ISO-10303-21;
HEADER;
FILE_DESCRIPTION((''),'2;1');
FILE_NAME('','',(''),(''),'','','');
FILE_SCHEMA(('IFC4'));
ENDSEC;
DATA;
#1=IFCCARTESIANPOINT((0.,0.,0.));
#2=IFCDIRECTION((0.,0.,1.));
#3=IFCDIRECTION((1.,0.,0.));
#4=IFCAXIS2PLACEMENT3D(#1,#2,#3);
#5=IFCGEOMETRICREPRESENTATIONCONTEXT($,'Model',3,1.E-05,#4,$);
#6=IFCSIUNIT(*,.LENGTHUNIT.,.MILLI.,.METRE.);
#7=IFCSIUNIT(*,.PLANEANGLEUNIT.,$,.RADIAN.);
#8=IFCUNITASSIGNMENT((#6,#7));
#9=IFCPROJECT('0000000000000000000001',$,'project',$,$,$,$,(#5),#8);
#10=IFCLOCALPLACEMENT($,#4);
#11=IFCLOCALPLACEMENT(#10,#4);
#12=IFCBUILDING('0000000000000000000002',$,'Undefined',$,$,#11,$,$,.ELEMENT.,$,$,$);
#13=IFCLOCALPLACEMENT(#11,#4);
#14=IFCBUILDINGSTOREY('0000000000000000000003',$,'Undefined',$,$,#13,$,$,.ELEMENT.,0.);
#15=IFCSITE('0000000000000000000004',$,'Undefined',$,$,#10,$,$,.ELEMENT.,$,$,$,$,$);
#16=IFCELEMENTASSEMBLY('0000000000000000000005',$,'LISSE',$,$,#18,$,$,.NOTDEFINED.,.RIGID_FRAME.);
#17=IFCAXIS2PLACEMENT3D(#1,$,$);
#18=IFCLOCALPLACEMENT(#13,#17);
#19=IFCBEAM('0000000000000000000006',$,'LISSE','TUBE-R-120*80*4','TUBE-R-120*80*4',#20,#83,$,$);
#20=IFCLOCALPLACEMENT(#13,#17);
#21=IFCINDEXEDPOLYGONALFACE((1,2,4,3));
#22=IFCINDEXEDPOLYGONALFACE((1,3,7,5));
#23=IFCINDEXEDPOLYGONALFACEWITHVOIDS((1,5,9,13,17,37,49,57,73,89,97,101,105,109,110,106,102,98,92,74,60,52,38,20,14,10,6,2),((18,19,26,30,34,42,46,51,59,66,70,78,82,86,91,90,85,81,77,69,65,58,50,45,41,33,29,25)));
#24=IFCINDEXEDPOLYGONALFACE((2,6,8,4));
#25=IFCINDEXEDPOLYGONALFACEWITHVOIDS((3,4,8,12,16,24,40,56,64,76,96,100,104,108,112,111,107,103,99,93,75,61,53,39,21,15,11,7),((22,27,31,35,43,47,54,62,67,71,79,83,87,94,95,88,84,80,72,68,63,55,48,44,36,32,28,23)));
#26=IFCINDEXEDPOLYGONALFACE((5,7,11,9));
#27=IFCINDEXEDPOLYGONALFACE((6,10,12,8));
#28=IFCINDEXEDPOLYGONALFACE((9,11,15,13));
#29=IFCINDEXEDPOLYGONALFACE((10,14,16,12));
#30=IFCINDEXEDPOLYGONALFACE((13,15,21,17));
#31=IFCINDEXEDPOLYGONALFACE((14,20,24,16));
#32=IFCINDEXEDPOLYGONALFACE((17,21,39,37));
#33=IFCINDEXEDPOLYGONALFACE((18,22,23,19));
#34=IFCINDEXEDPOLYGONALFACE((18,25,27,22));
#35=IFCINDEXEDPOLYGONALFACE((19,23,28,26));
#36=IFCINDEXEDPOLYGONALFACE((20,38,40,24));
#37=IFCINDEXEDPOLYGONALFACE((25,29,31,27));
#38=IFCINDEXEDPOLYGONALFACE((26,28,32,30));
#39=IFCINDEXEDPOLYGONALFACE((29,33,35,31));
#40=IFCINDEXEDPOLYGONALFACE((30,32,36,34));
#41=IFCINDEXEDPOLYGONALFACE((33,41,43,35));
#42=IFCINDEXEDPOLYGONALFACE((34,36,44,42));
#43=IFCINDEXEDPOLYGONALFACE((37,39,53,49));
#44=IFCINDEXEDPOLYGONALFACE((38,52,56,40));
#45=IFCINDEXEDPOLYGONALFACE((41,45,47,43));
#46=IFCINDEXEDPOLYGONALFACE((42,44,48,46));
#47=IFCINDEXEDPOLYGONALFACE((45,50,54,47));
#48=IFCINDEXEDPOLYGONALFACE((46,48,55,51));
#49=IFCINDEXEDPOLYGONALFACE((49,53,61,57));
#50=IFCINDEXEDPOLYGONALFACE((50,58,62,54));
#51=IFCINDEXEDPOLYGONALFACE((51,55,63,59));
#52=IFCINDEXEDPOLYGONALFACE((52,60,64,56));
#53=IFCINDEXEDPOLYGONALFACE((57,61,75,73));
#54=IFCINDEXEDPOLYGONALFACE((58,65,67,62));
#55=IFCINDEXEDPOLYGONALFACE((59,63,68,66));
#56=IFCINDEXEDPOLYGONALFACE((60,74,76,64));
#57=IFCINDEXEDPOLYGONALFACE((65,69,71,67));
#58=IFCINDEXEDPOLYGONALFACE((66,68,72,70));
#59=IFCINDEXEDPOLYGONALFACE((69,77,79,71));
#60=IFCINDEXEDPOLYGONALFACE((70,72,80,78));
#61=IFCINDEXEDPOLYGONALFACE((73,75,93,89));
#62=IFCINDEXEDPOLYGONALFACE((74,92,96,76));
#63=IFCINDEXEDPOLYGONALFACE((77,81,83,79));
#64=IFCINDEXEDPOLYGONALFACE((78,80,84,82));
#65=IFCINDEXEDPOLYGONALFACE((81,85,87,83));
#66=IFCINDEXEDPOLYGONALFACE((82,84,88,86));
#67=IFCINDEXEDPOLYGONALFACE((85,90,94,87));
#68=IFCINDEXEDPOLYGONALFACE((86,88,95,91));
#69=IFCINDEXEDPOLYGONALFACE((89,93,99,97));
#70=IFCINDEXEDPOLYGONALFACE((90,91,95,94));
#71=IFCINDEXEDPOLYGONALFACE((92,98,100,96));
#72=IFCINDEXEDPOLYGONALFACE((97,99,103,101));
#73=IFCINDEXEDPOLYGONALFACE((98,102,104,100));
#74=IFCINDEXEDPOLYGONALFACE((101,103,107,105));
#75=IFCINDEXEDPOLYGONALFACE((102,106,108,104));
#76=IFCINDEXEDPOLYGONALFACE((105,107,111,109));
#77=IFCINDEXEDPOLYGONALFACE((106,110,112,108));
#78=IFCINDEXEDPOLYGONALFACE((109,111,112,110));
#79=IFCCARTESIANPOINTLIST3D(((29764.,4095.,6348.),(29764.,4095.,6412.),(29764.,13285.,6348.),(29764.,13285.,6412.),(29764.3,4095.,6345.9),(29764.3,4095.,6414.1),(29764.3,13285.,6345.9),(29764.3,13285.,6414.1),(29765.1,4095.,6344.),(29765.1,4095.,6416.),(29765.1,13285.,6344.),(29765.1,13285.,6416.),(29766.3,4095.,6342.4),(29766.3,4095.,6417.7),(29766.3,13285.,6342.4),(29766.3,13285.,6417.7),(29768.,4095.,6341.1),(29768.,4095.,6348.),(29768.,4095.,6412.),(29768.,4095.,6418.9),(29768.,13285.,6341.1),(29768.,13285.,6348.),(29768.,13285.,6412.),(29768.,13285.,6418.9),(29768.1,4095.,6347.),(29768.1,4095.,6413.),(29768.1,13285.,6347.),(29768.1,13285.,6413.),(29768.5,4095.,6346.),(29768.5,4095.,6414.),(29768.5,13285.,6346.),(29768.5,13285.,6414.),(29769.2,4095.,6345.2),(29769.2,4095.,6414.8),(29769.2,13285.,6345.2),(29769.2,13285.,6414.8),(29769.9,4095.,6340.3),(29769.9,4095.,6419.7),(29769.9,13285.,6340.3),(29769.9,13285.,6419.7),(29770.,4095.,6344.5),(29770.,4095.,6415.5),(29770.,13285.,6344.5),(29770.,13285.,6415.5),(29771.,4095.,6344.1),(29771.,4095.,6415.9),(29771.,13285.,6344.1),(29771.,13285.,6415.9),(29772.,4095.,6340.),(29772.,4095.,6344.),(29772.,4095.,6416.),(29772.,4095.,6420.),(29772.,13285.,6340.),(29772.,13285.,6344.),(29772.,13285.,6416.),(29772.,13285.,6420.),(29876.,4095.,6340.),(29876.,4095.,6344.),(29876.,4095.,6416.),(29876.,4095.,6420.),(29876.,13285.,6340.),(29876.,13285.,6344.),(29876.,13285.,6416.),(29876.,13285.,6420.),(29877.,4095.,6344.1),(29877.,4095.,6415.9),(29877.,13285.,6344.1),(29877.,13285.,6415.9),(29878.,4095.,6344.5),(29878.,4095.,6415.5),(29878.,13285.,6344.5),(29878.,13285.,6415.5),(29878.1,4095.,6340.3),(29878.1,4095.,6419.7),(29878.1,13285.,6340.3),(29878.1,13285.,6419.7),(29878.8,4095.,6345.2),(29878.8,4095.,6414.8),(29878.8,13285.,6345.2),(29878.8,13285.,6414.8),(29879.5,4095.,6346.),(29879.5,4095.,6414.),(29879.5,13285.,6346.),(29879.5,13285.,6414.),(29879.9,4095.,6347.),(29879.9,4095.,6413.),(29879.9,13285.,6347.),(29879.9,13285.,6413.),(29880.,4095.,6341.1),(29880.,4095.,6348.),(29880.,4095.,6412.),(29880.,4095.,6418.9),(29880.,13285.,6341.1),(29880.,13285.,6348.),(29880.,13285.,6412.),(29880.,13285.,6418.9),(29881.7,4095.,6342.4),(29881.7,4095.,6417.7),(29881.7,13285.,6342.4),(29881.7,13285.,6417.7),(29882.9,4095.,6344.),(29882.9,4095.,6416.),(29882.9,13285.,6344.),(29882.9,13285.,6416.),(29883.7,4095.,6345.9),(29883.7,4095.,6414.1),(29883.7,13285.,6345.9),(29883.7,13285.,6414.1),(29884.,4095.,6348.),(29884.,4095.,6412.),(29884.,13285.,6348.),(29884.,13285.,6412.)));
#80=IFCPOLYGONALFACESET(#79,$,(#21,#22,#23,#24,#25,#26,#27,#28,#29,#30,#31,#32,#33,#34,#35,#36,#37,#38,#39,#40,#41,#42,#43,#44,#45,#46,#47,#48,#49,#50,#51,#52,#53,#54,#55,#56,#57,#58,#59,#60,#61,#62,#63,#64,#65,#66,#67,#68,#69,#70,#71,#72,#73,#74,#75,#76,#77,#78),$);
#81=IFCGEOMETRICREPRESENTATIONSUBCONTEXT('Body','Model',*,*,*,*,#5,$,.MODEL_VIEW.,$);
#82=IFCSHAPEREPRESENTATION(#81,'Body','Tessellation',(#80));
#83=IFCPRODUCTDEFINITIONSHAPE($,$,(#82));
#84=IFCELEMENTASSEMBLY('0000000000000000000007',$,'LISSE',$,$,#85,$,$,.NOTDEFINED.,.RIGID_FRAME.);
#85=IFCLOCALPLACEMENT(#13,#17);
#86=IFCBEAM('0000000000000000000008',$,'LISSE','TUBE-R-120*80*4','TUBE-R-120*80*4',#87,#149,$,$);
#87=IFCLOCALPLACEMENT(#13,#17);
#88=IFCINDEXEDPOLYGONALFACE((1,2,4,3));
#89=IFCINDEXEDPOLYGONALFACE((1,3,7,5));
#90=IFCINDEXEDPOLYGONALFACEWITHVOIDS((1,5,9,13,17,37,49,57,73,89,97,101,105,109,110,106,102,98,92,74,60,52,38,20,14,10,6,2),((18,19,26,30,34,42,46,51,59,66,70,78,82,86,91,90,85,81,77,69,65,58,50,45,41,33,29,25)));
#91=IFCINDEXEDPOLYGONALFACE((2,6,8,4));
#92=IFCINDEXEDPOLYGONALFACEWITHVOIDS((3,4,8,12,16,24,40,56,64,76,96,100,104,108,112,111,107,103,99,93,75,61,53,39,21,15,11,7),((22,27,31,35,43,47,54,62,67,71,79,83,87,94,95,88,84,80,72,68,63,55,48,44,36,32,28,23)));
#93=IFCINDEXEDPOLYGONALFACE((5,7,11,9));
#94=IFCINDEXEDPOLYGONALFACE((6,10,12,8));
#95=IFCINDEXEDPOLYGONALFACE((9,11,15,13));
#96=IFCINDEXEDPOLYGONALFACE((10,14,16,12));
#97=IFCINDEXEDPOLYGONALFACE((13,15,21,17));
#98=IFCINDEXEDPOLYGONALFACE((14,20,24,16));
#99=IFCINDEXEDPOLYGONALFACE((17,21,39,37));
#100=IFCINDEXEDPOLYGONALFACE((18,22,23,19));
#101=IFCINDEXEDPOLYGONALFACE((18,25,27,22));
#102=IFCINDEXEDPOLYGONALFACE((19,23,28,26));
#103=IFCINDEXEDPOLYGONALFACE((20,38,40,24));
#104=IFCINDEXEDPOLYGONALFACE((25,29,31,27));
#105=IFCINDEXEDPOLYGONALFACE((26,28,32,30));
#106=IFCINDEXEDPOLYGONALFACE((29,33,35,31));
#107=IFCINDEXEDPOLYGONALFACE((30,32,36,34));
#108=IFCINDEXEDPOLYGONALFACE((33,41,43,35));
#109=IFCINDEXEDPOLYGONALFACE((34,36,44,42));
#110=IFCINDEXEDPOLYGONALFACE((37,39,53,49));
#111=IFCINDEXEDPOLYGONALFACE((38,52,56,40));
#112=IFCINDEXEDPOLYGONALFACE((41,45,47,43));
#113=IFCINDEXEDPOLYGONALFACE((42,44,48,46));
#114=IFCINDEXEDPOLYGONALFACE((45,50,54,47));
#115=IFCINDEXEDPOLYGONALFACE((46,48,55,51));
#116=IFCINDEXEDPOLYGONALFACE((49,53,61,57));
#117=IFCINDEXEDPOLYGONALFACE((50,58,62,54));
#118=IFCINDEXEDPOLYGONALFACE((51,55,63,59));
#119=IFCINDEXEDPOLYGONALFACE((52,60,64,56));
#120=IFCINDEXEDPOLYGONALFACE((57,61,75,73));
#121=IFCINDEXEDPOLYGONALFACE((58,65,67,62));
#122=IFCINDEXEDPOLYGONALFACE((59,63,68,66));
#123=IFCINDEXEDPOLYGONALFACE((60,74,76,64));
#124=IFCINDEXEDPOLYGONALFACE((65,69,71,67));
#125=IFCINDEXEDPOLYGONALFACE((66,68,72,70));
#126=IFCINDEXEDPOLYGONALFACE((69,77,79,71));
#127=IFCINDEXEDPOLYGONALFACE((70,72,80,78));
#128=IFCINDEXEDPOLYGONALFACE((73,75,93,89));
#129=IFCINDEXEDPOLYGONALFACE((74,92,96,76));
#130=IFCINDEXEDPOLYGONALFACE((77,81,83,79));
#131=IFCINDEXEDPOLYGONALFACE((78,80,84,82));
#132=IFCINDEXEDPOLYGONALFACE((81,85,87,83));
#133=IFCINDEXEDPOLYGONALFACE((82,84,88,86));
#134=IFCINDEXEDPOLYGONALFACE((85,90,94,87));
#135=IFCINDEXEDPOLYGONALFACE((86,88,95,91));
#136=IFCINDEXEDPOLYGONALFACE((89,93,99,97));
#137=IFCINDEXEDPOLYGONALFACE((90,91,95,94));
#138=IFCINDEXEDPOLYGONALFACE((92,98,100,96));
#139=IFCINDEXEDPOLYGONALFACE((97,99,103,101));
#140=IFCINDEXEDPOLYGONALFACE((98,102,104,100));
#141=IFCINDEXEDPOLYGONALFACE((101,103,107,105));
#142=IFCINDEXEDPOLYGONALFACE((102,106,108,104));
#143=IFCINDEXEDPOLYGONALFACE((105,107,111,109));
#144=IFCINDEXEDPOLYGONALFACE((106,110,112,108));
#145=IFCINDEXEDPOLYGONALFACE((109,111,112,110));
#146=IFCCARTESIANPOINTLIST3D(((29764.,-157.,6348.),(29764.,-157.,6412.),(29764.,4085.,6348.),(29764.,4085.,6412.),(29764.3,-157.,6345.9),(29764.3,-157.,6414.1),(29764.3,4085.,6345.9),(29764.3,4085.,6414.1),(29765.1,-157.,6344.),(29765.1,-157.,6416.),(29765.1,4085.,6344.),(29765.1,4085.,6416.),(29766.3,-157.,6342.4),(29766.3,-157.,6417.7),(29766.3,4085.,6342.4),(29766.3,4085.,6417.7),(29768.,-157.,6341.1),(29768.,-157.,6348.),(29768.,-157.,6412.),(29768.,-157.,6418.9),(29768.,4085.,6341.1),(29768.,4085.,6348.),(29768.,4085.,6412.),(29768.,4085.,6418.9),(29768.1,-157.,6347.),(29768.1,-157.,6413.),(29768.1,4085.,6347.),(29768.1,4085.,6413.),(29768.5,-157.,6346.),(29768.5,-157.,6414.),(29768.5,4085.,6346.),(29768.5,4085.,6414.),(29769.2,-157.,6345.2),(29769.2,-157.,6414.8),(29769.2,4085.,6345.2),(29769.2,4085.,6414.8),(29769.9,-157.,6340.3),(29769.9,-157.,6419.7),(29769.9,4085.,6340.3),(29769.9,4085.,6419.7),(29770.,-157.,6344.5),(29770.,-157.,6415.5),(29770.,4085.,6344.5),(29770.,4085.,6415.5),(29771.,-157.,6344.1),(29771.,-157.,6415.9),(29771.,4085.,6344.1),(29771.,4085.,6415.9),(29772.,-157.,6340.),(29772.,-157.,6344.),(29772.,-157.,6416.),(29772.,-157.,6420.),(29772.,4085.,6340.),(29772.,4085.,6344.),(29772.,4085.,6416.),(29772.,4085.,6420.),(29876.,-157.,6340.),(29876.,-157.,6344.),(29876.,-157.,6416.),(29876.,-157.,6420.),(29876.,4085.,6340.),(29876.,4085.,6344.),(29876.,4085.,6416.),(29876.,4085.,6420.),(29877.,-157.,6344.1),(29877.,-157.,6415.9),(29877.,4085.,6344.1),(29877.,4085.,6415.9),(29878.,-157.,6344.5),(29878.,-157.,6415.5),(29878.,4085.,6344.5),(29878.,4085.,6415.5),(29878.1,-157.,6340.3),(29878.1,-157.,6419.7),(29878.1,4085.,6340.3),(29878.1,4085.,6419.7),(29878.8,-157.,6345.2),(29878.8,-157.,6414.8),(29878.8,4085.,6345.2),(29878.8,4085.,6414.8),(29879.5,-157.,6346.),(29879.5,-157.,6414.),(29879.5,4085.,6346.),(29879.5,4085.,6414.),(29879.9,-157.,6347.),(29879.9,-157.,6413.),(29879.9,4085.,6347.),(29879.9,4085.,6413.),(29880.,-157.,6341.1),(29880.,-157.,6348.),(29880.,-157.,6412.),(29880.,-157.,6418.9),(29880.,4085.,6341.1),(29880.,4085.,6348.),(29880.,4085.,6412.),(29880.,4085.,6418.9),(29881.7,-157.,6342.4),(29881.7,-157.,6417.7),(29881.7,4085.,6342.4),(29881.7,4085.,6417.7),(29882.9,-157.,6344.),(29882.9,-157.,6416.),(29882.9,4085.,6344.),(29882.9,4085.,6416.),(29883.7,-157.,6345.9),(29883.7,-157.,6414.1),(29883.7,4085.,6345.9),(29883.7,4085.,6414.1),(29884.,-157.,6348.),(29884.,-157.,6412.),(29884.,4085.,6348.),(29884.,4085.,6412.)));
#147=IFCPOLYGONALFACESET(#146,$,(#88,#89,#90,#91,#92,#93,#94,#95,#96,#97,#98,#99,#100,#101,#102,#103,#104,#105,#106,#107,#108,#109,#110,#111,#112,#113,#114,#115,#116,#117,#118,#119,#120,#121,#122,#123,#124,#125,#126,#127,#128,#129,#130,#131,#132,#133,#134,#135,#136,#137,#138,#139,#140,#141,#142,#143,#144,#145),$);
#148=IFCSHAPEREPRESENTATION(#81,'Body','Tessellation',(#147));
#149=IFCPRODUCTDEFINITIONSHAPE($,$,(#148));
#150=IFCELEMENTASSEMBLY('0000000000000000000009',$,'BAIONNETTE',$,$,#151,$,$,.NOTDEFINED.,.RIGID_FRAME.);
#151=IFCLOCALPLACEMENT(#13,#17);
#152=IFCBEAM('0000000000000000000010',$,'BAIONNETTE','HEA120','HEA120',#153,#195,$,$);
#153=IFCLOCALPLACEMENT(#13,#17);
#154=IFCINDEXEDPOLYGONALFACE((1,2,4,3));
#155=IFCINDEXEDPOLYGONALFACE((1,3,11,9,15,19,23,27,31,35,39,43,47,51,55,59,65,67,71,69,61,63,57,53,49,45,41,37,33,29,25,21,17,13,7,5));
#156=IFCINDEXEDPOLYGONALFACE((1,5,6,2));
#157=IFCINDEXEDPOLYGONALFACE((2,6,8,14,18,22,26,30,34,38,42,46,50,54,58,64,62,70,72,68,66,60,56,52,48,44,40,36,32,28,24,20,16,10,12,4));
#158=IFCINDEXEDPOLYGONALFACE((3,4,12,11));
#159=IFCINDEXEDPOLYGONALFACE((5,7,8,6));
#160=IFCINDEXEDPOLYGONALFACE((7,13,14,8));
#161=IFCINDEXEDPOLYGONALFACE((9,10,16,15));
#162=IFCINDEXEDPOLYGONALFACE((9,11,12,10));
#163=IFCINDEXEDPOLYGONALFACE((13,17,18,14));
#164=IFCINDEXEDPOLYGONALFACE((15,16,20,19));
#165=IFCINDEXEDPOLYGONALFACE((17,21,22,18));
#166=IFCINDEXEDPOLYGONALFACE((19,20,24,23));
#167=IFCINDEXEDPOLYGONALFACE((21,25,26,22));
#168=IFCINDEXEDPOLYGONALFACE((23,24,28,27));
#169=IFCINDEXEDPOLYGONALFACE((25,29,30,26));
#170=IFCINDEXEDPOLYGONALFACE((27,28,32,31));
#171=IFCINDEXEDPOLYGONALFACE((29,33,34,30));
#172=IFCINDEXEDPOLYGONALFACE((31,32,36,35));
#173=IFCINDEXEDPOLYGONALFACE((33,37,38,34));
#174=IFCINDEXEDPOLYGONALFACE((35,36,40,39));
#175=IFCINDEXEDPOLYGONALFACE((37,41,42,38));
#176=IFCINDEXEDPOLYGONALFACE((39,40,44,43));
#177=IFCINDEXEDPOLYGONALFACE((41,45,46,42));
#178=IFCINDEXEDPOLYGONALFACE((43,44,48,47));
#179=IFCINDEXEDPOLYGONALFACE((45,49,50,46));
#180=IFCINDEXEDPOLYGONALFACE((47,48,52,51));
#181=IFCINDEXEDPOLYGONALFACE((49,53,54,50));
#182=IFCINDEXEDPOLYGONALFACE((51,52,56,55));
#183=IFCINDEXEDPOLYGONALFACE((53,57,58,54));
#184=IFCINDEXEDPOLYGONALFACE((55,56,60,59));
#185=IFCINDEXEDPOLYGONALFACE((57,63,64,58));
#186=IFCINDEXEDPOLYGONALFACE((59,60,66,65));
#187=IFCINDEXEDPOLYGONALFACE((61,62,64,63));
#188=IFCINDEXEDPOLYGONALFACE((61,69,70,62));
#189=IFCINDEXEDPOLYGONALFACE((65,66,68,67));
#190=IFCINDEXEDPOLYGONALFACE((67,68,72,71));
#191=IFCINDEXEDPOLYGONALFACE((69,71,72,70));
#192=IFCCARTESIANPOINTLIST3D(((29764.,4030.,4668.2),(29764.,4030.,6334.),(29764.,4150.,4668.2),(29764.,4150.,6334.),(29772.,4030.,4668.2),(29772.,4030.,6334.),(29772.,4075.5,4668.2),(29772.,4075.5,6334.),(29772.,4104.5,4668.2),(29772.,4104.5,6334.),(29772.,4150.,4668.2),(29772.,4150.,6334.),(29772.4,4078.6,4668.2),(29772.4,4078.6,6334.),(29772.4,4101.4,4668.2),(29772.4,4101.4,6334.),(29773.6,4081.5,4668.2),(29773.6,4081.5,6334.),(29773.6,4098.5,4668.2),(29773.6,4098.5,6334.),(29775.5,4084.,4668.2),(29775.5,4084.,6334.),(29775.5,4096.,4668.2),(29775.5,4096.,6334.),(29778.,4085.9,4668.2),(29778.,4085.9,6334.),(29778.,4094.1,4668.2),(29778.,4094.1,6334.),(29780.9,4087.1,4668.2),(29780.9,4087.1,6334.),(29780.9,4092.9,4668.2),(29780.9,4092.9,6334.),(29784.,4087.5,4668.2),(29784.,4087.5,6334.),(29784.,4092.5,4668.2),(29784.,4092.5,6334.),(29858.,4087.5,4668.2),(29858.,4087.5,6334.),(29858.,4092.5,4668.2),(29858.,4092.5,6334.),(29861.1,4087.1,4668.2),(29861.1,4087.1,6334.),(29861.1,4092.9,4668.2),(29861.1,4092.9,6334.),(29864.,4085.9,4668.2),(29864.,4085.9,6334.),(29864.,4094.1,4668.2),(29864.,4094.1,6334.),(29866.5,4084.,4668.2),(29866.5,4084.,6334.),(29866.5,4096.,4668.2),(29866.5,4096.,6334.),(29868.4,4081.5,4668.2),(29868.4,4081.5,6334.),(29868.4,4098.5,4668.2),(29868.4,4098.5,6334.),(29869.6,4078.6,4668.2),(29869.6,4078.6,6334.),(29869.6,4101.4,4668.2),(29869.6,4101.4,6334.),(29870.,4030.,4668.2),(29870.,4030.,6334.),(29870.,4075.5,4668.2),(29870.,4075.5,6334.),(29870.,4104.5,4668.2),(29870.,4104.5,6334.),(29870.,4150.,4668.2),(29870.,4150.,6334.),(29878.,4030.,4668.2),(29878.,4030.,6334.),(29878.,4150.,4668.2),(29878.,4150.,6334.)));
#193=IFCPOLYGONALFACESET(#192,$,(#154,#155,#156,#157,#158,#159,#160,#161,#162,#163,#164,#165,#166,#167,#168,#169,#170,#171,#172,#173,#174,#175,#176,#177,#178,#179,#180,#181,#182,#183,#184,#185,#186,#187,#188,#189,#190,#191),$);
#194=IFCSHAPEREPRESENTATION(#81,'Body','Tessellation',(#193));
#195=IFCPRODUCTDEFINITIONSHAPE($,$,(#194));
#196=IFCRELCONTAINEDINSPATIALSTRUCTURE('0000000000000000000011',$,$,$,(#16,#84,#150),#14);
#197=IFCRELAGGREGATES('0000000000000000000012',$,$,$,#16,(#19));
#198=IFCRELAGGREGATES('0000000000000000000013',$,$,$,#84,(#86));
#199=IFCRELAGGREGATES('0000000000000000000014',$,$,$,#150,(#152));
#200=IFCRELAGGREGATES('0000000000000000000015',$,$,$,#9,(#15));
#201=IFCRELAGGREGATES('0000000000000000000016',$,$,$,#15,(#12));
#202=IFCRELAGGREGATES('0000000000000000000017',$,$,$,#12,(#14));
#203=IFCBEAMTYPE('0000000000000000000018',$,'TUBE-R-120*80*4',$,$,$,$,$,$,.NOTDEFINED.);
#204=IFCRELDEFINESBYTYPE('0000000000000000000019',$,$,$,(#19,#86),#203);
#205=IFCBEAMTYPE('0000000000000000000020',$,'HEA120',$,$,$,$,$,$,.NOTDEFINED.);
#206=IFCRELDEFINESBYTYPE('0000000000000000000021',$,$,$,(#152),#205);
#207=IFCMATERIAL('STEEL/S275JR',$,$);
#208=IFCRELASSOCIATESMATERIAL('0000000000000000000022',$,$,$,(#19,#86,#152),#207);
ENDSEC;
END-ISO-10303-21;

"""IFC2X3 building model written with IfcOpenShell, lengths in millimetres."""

from ifc_helpers import new_model, si_unit, frame, origin_with_axes, origin_2d_with_axis, place, context, subcontext, project, spatial, hollow_rectangle, i_section, extrude, clip, halfspace, material, type_object, element, aggregate, save


model = new_model("IFC2X3")

# Units and contexts
model_context = context("Model", 3, precision=1e-05, world=origin_with_axes())
body_context = subcontext(model_context, "Body", "Model", "MODEL_VIEW")
ifc_project = project(units=[si_unit("LENGTHUNIT", "METRE", prefix="MILLI"), si_unit("PLANEANGLEUNIT", "RADIAN")], contexts=[model_context])

# Site, building, storey
site_placement = place(None, origin_with_axes())
site = spatial("IfcSite", under=ifc_project, at=site_placement, Name="Undefined", CompositionType="ELEMENT")
building_placement = place(site_placement, origin_with_axes())
building = spatial("IfcBuilding", under=site, at=building_placement, Name="Undefined", CompositionType="ELEMENT")
storey_placement = place(building_placement, origin_with_axes())
storey = spatial("IfcBuildingStorey", under=building, at=storey_placement, Name="Undefined", CompositionType="ELEMENT", Elevation=0.0)

# Shared definitions
ifc_material_1 = material(Name="STEEL/S275JR")

# Element assemblies, beams
assembly_1_placement = place(storey_placement, origin_with_axes())
assembly_1 = element("IfcElementAssembly", 1, at=assembly_1_placement, inside=storey, Name="LISSE", AssemblyPlace="NOTDEFINED", PredefinedType="RIGID_FRAME")
beam_type_1 = type_object("IfcBeamType", Name="TUBE-R-120*80*4", PredefinedType="NOTDEFINED")
beam_1_placement = place(assembly_1_placement, frame((29824.0, 4090.0, 6380.0), z_axis=(1.0, 0.0, 0.0), x_axis=(0.0, 1.0, 0.0)))
beam_1 = element("IfcBeam", 2, at=beam_1_placement, type_object=beam_type_1, material=ifc_material_1, Name="LISSE", Description="TUBE-R-120*80*4", ObjectType="TUBE-R-120*80*4", context=body_context, shape_type="Clipping", body=[
    clip(clip(extrude(hollow_rectangle(XDim=80.0, YDim=120.0, WallThickness=4.0, InnerFilletRadius=4.0, OuterFilletRadius=8.0, at=origin_2d_with_axis()), frame((9195.0, 0.0, 0.0), z_axis=(-1.0, 0.0, 0.0), x_axis=(0.0, -1.0, 0.0)), (0.0, 0.0, 1.0), 9190.0), halfspace(frame((9195.0, 28.8, -60.0), z_axis=(1.0, 0.0, 0.0), x_axis=(0.0, 0.0, -1.0)), False)), halfspace(frame((5.0, 28.5, -60.0), z_axis=(1.0, 0.0, 0.0), x_axis=(0.0, 0.0, -1.0)), True)),
])
assembly_2_placement = place(storey_placement, origin_with_axes())
assembly_2 = element("IfcElementAssembly", 3, at=assembly_2_placement, inside=storey, Name="LISSE", AssemblyPlace="NOTDEFINED", PredefinedType="RIGID_FRAME")
beam_2_placement = place(assembly_2_placement, frame((29824.0, -160.0, 6380.0), z_axis=(1.0, 0.0, 0.0), x_axis=(0.0, 1.0, 0.0)))
beam_2 = element("IfcBeam", 4, at=beam_2_placement, type_object=beam_type_1, material=ifc_material_1, Name="LISSE", Description="TUBE-R-120*80*4", ObjectType="TUBE-R-120*80*4", context=body_context, shape_type="Clipping", body=[
    clip(clip(extrude(hollow_rectangle(XDim=80.0, YDim=120.0, WallThickness=4.0, InnerFilletRadius=4.0, OuterFilletRadius=8.0, at=origin_2d_with_axis()), frame((4245.0, 0.0, 0.0), z_axis=(-1.0, 0.0, 0.0), x_axis=(0.0, -1.0, 0.0)), (0.0, 0.0, 1.0), 4242.0), halfspace(frame((4245.0, 28.8, -60.0), z_axis=(1.0, 0.0, 0.0), x_axis=(0.0, 0.0, -1.0)), False)), halfspace(frame((3.0, -60.0, 45.0), z_axis=(1.0, 0.0, 0.0), x_axis=(0.0, 1.0, 0.0)), True)),
])
assembly_3_placement = place(storey_placement, origin_with_axes())
assembly_3 = element("IfcElementAssembly", 5, at=assembly_3_placement, inside=storey, Name="BAIONNETTE", AssemblyPlace="NOTDEFINED", PredefinedType="RIGID_FRAME")
beam_type_2 = type_object("IfcBeamType", Name="HEA120", PredefinedType="NOTDEFINED")
beam_3_placement = place(assembly_3_placement, frame((29821.0, 4090.0, 6420.0), z_axis=(1.0, 0.0, 0.0), x_axis=(0.0, 0.0, -1.0)))
beam_3 = element("IfcBeam", 6, at=beam_3_placement, type_object=beam_type_2, material=ifc_material_1, Name="BAIONNETTE", Description="HEA120", ObjectType="HEA120", context=body_context, shape_type="Clipping", body=[
    clip(extrude(i_section(OverallWidth=120.0, OverallDepth=114.0, WebThickness=5.0, FlangeThickness=8.0, FilletRadius=12.0, at=origin_2d_with_axis()), frame((1751.8, 0.0, 0.0), z_axis=(-1.0, 0.0, 0.0), x_axis=(0.0, -1.0, 0.0)), (0.0, 0.0, 1.0), 1665.8), halfspace(frame((86.0, 0.0, -36.4), z_axis=(1.0, 0.0, 0.0), x_axis=(0.0, 0.0, 1.0)), True)),
])

aggregate(assembly_1, [beam_1])
aggregate(assembly_2, [beam_2])
aggregate(assembly_3, [beam_3])

save(model, "model.ifc")
